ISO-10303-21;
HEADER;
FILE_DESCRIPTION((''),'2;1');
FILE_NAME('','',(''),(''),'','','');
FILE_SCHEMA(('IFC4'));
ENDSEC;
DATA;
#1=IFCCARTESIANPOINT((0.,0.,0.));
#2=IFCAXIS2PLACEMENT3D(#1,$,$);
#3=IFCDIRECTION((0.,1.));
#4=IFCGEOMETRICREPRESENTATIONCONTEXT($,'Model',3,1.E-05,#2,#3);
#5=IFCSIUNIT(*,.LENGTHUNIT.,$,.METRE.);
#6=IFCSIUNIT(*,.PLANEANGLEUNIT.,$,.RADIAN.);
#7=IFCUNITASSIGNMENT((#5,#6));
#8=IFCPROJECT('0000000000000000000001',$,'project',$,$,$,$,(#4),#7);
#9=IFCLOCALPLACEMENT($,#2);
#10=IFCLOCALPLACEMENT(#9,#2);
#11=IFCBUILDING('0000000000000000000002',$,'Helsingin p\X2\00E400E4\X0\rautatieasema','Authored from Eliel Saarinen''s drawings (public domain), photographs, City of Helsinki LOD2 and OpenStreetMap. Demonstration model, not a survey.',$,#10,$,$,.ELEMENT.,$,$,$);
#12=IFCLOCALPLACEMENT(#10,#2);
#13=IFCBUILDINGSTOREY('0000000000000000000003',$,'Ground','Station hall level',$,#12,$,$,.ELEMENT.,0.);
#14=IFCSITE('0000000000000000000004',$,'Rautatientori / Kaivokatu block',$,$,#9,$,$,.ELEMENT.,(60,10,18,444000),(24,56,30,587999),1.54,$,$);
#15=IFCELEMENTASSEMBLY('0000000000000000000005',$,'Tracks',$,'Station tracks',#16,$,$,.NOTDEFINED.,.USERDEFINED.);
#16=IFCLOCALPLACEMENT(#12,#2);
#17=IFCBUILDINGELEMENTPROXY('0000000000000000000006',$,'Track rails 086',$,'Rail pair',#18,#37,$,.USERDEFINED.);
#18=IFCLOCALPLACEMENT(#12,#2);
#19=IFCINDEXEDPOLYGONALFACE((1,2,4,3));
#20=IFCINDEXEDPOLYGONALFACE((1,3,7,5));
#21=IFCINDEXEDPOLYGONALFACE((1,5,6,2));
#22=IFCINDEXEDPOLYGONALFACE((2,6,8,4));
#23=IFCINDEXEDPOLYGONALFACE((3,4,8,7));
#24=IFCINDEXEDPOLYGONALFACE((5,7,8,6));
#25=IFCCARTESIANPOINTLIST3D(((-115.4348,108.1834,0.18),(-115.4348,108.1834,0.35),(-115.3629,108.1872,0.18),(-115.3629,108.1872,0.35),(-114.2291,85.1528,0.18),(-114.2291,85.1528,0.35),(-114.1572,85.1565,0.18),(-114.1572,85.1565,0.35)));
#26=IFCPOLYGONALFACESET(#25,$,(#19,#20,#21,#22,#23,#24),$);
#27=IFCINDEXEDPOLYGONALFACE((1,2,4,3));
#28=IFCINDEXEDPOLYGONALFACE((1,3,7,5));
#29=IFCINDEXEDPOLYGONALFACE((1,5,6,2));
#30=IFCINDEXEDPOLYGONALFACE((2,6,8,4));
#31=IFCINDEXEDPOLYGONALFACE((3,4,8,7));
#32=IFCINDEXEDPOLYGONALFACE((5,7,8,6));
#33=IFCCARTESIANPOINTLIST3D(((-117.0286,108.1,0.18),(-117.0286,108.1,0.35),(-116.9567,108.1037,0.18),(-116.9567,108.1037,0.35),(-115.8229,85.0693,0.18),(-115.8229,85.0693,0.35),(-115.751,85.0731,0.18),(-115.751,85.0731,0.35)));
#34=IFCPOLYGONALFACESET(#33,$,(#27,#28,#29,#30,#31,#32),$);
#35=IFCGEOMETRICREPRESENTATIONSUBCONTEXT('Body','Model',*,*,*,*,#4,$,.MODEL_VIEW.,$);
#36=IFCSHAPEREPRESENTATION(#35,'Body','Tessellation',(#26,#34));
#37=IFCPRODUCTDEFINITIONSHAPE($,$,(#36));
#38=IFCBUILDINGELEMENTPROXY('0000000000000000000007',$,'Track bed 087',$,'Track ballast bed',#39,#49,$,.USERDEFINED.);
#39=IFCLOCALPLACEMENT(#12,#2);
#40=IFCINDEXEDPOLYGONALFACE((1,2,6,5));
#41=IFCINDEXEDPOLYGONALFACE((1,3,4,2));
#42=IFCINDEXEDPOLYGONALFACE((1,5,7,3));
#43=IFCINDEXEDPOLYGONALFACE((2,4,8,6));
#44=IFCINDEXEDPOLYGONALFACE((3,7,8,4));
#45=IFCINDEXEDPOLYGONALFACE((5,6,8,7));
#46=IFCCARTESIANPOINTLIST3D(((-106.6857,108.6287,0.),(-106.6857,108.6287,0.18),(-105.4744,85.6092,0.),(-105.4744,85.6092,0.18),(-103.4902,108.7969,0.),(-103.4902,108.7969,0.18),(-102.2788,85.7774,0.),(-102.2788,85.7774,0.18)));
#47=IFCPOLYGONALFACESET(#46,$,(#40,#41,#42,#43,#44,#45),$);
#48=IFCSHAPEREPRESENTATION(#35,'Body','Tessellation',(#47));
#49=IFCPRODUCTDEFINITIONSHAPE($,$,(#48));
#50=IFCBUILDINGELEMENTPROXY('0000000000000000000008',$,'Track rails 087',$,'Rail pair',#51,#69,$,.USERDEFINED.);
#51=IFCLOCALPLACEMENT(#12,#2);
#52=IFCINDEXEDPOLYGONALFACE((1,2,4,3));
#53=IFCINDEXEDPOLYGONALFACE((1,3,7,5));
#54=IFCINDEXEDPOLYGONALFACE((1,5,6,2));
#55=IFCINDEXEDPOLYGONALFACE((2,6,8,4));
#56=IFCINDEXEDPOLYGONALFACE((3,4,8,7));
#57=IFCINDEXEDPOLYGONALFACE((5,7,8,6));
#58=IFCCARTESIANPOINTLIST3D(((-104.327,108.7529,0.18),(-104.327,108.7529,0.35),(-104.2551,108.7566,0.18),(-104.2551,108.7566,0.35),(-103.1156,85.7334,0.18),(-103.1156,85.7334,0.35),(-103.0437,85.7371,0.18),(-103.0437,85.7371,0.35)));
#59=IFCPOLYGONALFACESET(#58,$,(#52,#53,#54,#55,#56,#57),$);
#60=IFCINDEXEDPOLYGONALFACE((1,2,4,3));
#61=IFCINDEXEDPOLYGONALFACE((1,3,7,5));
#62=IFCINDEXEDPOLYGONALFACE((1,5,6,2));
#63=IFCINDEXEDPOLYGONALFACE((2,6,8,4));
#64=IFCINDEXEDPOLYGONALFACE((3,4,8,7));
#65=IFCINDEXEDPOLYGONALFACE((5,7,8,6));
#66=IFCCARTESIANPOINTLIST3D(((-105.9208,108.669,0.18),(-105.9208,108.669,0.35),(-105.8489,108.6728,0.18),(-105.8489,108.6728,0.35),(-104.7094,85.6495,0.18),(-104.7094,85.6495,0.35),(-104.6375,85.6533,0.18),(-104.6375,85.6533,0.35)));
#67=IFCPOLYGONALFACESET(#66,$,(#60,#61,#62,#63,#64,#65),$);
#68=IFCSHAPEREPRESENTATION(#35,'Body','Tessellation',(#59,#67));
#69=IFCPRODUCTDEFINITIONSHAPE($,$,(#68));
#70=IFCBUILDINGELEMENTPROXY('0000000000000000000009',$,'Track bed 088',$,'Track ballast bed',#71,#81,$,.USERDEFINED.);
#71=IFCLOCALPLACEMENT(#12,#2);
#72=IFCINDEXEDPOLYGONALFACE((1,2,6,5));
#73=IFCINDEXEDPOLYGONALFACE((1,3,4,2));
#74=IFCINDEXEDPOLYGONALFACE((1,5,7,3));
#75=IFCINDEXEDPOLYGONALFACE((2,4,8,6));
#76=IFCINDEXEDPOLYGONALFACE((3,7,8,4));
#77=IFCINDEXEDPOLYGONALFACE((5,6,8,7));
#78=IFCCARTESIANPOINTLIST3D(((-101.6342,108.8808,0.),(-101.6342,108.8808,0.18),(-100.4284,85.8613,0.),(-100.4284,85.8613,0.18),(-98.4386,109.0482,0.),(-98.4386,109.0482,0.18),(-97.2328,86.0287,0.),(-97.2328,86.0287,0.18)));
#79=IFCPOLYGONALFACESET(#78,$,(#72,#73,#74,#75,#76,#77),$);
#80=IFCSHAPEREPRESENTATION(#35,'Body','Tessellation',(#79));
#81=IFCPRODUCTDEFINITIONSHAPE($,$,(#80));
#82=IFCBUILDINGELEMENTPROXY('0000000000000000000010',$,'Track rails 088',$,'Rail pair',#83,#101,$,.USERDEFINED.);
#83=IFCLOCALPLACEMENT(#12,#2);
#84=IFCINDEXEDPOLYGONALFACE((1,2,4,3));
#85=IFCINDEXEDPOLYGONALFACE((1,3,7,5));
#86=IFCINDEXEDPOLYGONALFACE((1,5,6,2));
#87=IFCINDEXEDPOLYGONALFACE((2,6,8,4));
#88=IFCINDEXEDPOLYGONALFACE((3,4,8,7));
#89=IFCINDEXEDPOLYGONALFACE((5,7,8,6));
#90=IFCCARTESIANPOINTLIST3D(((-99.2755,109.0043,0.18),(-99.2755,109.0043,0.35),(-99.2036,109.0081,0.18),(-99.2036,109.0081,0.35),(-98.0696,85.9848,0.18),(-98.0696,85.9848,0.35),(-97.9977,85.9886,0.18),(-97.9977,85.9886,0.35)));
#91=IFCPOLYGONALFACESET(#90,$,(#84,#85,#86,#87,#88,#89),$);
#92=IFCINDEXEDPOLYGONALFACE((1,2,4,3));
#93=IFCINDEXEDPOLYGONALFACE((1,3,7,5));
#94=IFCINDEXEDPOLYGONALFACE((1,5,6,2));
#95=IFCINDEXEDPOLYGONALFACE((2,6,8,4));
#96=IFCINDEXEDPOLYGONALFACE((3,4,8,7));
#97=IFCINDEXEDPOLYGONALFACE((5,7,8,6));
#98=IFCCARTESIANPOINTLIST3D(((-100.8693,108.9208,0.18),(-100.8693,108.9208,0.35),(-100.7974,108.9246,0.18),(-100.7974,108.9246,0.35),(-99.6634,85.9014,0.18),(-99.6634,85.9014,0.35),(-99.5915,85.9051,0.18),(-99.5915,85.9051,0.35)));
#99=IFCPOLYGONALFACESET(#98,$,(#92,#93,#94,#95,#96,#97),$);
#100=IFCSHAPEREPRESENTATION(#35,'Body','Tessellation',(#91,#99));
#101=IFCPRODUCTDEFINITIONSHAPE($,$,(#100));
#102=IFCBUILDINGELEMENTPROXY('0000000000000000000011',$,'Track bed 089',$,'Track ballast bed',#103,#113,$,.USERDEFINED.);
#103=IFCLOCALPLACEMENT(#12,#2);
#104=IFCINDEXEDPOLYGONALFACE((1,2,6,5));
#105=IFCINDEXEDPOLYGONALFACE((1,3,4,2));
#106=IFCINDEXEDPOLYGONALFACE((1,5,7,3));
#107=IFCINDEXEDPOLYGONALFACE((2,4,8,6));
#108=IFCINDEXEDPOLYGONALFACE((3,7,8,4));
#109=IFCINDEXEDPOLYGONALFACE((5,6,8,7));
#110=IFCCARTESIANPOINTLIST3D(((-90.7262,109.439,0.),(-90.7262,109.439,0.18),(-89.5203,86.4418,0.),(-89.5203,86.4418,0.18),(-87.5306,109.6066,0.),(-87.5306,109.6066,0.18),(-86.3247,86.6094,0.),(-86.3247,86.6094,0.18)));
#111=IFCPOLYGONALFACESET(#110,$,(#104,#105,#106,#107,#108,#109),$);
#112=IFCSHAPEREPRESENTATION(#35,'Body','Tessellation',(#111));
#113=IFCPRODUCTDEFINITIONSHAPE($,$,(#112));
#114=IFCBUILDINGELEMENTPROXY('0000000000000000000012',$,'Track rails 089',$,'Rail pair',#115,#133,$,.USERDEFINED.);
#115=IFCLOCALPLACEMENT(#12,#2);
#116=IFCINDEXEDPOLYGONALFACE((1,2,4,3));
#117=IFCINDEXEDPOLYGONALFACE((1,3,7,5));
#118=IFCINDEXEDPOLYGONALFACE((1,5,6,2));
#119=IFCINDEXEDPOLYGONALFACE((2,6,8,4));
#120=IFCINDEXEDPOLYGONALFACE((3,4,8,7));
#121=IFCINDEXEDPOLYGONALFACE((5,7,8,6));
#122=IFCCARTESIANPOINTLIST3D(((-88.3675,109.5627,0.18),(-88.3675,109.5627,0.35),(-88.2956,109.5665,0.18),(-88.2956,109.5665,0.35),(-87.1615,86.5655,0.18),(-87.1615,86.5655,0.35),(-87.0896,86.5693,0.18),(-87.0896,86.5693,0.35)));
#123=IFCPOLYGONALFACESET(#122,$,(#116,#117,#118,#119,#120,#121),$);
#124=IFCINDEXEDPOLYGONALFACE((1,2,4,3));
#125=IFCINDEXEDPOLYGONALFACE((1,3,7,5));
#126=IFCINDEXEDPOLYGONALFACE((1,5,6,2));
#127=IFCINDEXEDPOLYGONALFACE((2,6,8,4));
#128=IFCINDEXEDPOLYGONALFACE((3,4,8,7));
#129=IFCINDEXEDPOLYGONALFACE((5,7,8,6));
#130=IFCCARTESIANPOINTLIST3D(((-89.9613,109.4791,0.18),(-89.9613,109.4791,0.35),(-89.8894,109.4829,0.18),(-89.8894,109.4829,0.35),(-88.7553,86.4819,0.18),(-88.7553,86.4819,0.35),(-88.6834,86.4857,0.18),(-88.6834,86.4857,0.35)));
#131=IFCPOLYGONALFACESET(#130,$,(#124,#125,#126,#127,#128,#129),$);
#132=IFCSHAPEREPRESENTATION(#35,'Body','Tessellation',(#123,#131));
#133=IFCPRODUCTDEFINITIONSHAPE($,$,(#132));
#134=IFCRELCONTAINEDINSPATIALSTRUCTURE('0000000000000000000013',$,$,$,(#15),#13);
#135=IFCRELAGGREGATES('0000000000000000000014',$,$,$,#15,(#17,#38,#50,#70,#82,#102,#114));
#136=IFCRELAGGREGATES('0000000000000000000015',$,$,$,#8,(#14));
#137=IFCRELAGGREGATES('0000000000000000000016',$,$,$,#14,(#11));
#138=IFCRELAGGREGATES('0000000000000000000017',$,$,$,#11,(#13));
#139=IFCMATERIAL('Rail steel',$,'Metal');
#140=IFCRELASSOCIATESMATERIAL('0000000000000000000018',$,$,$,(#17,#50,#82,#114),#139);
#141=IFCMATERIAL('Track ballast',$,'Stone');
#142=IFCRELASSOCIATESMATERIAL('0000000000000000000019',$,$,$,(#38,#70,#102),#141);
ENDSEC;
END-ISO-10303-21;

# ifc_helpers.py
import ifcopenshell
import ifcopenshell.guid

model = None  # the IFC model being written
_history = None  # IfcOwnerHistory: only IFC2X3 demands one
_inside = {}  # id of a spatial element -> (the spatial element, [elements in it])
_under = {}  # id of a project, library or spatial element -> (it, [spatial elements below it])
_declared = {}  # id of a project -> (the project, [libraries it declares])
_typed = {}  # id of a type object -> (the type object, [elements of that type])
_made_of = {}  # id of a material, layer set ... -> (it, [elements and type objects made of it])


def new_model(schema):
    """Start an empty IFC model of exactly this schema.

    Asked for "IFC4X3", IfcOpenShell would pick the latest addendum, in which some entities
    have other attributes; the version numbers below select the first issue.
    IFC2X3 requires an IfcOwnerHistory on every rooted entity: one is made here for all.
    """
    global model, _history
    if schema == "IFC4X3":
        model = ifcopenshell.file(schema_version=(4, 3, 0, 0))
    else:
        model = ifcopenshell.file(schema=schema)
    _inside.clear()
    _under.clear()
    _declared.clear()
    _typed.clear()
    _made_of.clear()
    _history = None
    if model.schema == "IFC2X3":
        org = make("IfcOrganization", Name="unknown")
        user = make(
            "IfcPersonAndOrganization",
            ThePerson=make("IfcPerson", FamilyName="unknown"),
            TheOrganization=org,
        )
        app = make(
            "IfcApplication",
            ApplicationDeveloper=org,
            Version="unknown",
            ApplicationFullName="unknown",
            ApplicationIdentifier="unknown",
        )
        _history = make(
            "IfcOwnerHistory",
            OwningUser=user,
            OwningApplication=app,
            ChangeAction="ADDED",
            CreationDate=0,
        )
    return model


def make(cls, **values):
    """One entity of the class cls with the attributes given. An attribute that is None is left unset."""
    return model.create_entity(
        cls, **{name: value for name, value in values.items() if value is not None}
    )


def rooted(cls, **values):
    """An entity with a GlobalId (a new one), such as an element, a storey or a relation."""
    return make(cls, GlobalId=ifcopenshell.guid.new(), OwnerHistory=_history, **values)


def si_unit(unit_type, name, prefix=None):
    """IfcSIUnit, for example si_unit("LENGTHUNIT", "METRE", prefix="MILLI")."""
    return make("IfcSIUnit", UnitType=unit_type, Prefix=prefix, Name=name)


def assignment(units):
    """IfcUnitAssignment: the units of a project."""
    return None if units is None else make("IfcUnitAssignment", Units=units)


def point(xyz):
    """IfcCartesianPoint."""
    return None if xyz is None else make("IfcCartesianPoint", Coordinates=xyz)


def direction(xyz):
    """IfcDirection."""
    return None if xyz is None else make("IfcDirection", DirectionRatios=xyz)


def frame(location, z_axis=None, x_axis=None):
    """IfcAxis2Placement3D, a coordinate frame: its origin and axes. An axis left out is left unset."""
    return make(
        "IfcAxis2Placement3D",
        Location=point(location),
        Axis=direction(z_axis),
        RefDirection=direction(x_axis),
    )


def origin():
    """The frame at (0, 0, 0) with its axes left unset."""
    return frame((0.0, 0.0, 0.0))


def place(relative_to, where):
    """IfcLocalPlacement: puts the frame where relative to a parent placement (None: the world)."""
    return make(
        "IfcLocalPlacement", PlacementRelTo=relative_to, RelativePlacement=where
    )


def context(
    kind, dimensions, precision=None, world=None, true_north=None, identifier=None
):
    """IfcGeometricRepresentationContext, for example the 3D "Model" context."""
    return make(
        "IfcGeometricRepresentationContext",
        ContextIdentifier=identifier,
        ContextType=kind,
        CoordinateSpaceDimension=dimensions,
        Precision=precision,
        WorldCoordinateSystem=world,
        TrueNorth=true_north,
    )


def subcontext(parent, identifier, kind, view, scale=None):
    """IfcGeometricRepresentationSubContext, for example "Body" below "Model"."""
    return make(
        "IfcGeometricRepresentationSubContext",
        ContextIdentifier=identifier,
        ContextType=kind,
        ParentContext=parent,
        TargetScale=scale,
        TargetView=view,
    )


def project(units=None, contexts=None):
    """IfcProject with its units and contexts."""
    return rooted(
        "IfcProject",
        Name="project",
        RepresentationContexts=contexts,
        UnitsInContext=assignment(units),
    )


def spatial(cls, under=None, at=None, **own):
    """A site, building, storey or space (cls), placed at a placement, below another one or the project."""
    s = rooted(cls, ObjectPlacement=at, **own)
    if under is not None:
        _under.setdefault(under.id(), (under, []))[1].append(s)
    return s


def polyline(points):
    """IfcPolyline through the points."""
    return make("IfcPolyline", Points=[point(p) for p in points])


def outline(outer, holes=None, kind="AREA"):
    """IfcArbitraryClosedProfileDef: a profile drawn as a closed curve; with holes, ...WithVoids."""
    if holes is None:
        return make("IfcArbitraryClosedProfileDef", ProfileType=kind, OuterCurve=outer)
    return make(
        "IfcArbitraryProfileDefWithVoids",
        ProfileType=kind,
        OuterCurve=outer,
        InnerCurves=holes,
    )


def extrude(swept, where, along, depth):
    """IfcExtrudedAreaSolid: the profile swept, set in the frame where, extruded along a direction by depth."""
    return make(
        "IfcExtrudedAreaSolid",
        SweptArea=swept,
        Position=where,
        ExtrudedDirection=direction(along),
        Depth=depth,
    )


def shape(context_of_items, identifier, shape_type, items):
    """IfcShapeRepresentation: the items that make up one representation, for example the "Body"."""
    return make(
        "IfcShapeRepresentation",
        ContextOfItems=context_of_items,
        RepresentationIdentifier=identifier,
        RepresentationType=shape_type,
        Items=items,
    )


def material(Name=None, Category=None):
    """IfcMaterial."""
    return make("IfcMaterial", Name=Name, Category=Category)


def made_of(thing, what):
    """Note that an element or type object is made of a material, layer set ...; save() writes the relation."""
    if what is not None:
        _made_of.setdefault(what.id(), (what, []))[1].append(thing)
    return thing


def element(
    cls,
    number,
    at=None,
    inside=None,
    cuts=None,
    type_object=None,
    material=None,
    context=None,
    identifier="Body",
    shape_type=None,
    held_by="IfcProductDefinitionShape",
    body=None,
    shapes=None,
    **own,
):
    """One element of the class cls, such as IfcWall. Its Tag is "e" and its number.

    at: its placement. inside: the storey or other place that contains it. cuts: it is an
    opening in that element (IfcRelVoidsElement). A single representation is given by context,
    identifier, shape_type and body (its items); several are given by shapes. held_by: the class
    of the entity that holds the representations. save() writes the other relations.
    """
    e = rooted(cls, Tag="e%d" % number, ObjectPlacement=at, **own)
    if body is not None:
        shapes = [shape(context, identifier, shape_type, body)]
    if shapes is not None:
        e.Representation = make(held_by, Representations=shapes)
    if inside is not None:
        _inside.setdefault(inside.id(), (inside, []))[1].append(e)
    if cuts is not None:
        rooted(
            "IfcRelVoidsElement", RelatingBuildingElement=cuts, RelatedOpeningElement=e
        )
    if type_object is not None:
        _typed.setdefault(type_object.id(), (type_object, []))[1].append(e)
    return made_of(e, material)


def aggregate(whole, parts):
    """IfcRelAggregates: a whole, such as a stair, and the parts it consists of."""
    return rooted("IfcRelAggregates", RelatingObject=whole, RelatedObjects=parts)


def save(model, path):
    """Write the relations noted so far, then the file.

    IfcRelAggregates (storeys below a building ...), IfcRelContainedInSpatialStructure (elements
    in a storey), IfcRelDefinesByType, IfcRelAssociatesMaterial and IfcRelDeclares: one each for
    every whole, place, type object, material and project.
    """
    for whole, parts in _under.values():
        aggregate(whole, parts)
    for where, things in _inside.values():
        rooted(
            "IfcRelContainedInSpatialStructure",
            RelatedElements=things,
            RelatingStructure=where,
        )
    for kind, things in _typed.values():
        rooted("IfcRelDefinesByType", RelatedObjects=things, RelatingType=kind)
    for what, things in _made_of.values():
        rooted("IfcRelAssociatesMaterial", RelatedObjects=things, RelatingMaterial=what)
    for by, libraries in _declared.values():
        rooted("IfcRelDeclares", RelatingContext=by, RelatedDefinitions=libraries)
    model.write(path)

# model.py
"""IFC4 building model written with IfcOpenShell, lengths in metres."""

from ifc_helpers import new_model, si_unit, direction, frame, origin, place, context, subcontext, project, spatial, polyline, outline, extrude, material, element, aggregate, save


model = new_model("IFC4")

# Units and contexts
model_context = context("Model", 3, precision=1e-05, world=origin(), true_north=direction((0.0, 1.0)))
body_context = subcontext(model_context, "Body", "Model", "MODEL_VIEW")
ifc_project = project(units=[si_unit("LENGTHUNIT", "METRE"), si_unit("PLANEANGLEUNIT", "RADIAN")], contexts=[model_context])

# Site, building, storey
site_placement = place(None, origin())
site = spatial("IfcSite", under=ifc_project, at=site_placement, Name="Rautatientori / Kaivokatu block", CompositionType="ELEMENT", RefLatitude=(60, 10, 18, 444000), RefLongitude=(24, 56, 30, 587999), RefElevation=1.54)
building_placement = place(site_placement, origin())
building = spatial("IfcBuilding", under=site, at=building_placement, Name="Helsingin päärautatieasema", Description="Authored from Eliel Saarinen's drawings (public domain), photographs, City of Helsinki LOD2 and OpenStreetMap. Demonstration model, not a survey.", CompositionType="ELEMENT")
storey_placement = place(building_placement, origin())
storey = spatial("IfcBuildingStorey", under=building, at=storey_placement, Name="Ground", Description="Station hall level", CompositionType="ELEMENT", Elevation=0.0)

# Element assembly, building element proxies
assembly_placement = place(building_placement, origin())
assembly = element("IfcElementAssembly", 1, at=assembly_placement, inside=storey, Name="Tracks", ObjectType="Station tracks", AssemblyPlace="NOTDEFINED", PredefinedType="USERDEFINED")
ifc_material_1 = material(Name="Track ballast", Category="Stone")
ifc_material_2 = material(Name="Rail steel", Category="Metal")
proxy_1_placement = place(building_placement, origin())
proxy_1 = element("IfcBuildingElementProxy", 2, at=proxy_1_placement, material=ifc_material_2, Name="Track rails 086", ObjectType="Rail pair", PredefinedType="USERDEFINED", context=body_context, shape_type="SweptSolid", body=[
    extrude(outline(polyline([(-115.4348, 108.1834), (-115.3629, 108.1872), (-114.1572, 85.1565), (-114.2291, 85.1528), (-115.4348, 108.1834)])), frame((0.0, 0.0, 0.18)), (0.0, 0.0, 1.0), 0.17),
    extrude(outline(polyline([(-117.0286, 108.1), (-116.9567, 108.1037), (-115.751, 85.0731), (-115.8229, 85.0693), (-117.0286, 108.1)])), frame((0.0, 0.0, 0.18)), (0.0, 0.0, 1.0), 0.17),
])
proxy_2_placement = place(building_placement, origin())
proxy_2 = element("IfcBuildingElementProxy", 3, at=proxy_2_placement, material=ifc_material_1, Name="Track bed 087", ObjectType="Track ballast bed", PredefinedType="USERDEFINED", context=body_context, shape_type="SweptSolid", body=[
    extrude(outline(polyline([(-106.6857, 108.6287), (-103.4902, 108.7969), (-102.2788, 85.7774), (-105.4744, 85.6092), (-106.6857, 108.6287)])), origin(), (0.0, 0.0, 1.0), 0.18),
])
proxy_3_placement = place(building_placement, origin())
proxy_3 = element("IfcBuildingElementProxy", 4, at=proxy_3_placement, material=ifc_material_2, Name="Track rails 087", ObjectType="Rail pair", PredefinedType="USERDEFINED", context=body_context, shape_type="SweptSolid", body=[
    extrude(outline(polyline([(-104.327, 108.7529), (-104.2551, 108.7566), (-103.0437, 85.7371), (-103.1156, 85.7334), (-104.327, 108.7529)])), frame((0.0, 0.0, 0.18)), (0.0, 0.0, 1.0), 0.17),
    extrude(outline(polyline([(-105.9208, 108.669), (-105.8489, 108.6728), (-104.6375, 85.6533), (-104.7094, 85.6495), (-105.9208, 108.669)])), frame((0.0, 0.0, 0.18)), (0.0, 0.0, 1.0), 0.17),
])
proxy_4_placement = place(building_placement, origin())
proxy_4 = element("IfcBuildingElementProxy", 5, at=proxy_4_placement, material=ifc_material_1, Name="Track bed 088", ObjectType="Track ballast bed", PredefinedType="USERDEFINED", context=body_context, shape_type="SweptSolid", body=[
    extrude(outline(polyline([(-101.6342, 108.8808), (-98.4386, 109.0482), (-97.2328, 86.0287), (-100.4284, 85.8613), (-101.6342, 108.8808)])), origin(), (0.0, 0.0, 1.0), 0.18),
])
proxy_5_placement = place(building_placement, origin())
proxy_5 = element("IfcBuildingElementProxy", 6, at=proxy_5_placement, material=ifc_material_2, Name="Track rails 088", ObjectType="Rail pair", PredefinedType="USERDEFINED", context=body_context, shape_type="SweptSolid", body=[
    extrude(outline(polyline([(-99.2755, 109.0043), (-99.2036, 109.0081), (-97.9977, 85.9886), (-98.0696, 85.9848), (-99.2755, 109.0043)])), frame((0.0, 0.0, 0.18)), (0.0, 0.0, 1.0), 0.17),
    extrude(outline(polyline([(-100.8693, 108.9208), (-100.7974, 108.9246), (-99.5915, 85.9051), (-99.6634, 85.9014), (-100.8693, 108.9208)])), frame((0.0, 0.0, 0.18)), (0.0, 0.0, 1.0), 0.17),
])
proxy_6_placement = place(building_placement, origin())
proxy_6 = element("IfcBuildingElementProxy", 7, at=proxy_6_placement, material=ifc_material_1, Name="Track bed 089", ObjectType="Track ballast bed", PredefinedType="USERDEFINED", context=body_context, shape_type="SweptSolid", body=[
    extrude(outline(polyline([(-90.7262, 109.439), (-87.5306, 109.6066), (-86.3247, 86.6094), (-89.5203, 86.4418), (-90.7262, 109.439)])), origin(), (0.0, 0.0, 1.0), 0.18),
])
proxy_7_placement = place(building_placement, origin())
proxy_7 = element("IfcBuildingElementProxy", 8, at=proxy_7_placement, material=ifc_material_2, Name="Track rails 089", ObjectType="Rail pair", PredefinedType="USERDEFINED", context=body_context, shape_type="SweptSolid", body=[
    extrude(outline(polyline([(-88.3675, 109.5627), (-88.2956, 109.5665), (-87.0896, 86.5693), (-87.1615, 86.5655), (-88.3675, 109.5627)])), frame((0.0, 0.0, 0.18)), (0.0, 0.0, 1.0), 0.17),
    extrude(outline(polyline([(-89.9613, 109.4791), (-89.8894, 109.4829), (-88.6834, 86.4857), (-88.7553, 86.4819), (-89.9613, 109.4791)])), frame((0.0, 0.0, 0.18)), (0.0, 0.0, 1.0), 0.17),
])
aggregate(assembly, [proxy_1, proxy_2, proxy_3, proxy_4, proxy_5, proxy_6, proxy_7])

save(model, "model.ifc")
